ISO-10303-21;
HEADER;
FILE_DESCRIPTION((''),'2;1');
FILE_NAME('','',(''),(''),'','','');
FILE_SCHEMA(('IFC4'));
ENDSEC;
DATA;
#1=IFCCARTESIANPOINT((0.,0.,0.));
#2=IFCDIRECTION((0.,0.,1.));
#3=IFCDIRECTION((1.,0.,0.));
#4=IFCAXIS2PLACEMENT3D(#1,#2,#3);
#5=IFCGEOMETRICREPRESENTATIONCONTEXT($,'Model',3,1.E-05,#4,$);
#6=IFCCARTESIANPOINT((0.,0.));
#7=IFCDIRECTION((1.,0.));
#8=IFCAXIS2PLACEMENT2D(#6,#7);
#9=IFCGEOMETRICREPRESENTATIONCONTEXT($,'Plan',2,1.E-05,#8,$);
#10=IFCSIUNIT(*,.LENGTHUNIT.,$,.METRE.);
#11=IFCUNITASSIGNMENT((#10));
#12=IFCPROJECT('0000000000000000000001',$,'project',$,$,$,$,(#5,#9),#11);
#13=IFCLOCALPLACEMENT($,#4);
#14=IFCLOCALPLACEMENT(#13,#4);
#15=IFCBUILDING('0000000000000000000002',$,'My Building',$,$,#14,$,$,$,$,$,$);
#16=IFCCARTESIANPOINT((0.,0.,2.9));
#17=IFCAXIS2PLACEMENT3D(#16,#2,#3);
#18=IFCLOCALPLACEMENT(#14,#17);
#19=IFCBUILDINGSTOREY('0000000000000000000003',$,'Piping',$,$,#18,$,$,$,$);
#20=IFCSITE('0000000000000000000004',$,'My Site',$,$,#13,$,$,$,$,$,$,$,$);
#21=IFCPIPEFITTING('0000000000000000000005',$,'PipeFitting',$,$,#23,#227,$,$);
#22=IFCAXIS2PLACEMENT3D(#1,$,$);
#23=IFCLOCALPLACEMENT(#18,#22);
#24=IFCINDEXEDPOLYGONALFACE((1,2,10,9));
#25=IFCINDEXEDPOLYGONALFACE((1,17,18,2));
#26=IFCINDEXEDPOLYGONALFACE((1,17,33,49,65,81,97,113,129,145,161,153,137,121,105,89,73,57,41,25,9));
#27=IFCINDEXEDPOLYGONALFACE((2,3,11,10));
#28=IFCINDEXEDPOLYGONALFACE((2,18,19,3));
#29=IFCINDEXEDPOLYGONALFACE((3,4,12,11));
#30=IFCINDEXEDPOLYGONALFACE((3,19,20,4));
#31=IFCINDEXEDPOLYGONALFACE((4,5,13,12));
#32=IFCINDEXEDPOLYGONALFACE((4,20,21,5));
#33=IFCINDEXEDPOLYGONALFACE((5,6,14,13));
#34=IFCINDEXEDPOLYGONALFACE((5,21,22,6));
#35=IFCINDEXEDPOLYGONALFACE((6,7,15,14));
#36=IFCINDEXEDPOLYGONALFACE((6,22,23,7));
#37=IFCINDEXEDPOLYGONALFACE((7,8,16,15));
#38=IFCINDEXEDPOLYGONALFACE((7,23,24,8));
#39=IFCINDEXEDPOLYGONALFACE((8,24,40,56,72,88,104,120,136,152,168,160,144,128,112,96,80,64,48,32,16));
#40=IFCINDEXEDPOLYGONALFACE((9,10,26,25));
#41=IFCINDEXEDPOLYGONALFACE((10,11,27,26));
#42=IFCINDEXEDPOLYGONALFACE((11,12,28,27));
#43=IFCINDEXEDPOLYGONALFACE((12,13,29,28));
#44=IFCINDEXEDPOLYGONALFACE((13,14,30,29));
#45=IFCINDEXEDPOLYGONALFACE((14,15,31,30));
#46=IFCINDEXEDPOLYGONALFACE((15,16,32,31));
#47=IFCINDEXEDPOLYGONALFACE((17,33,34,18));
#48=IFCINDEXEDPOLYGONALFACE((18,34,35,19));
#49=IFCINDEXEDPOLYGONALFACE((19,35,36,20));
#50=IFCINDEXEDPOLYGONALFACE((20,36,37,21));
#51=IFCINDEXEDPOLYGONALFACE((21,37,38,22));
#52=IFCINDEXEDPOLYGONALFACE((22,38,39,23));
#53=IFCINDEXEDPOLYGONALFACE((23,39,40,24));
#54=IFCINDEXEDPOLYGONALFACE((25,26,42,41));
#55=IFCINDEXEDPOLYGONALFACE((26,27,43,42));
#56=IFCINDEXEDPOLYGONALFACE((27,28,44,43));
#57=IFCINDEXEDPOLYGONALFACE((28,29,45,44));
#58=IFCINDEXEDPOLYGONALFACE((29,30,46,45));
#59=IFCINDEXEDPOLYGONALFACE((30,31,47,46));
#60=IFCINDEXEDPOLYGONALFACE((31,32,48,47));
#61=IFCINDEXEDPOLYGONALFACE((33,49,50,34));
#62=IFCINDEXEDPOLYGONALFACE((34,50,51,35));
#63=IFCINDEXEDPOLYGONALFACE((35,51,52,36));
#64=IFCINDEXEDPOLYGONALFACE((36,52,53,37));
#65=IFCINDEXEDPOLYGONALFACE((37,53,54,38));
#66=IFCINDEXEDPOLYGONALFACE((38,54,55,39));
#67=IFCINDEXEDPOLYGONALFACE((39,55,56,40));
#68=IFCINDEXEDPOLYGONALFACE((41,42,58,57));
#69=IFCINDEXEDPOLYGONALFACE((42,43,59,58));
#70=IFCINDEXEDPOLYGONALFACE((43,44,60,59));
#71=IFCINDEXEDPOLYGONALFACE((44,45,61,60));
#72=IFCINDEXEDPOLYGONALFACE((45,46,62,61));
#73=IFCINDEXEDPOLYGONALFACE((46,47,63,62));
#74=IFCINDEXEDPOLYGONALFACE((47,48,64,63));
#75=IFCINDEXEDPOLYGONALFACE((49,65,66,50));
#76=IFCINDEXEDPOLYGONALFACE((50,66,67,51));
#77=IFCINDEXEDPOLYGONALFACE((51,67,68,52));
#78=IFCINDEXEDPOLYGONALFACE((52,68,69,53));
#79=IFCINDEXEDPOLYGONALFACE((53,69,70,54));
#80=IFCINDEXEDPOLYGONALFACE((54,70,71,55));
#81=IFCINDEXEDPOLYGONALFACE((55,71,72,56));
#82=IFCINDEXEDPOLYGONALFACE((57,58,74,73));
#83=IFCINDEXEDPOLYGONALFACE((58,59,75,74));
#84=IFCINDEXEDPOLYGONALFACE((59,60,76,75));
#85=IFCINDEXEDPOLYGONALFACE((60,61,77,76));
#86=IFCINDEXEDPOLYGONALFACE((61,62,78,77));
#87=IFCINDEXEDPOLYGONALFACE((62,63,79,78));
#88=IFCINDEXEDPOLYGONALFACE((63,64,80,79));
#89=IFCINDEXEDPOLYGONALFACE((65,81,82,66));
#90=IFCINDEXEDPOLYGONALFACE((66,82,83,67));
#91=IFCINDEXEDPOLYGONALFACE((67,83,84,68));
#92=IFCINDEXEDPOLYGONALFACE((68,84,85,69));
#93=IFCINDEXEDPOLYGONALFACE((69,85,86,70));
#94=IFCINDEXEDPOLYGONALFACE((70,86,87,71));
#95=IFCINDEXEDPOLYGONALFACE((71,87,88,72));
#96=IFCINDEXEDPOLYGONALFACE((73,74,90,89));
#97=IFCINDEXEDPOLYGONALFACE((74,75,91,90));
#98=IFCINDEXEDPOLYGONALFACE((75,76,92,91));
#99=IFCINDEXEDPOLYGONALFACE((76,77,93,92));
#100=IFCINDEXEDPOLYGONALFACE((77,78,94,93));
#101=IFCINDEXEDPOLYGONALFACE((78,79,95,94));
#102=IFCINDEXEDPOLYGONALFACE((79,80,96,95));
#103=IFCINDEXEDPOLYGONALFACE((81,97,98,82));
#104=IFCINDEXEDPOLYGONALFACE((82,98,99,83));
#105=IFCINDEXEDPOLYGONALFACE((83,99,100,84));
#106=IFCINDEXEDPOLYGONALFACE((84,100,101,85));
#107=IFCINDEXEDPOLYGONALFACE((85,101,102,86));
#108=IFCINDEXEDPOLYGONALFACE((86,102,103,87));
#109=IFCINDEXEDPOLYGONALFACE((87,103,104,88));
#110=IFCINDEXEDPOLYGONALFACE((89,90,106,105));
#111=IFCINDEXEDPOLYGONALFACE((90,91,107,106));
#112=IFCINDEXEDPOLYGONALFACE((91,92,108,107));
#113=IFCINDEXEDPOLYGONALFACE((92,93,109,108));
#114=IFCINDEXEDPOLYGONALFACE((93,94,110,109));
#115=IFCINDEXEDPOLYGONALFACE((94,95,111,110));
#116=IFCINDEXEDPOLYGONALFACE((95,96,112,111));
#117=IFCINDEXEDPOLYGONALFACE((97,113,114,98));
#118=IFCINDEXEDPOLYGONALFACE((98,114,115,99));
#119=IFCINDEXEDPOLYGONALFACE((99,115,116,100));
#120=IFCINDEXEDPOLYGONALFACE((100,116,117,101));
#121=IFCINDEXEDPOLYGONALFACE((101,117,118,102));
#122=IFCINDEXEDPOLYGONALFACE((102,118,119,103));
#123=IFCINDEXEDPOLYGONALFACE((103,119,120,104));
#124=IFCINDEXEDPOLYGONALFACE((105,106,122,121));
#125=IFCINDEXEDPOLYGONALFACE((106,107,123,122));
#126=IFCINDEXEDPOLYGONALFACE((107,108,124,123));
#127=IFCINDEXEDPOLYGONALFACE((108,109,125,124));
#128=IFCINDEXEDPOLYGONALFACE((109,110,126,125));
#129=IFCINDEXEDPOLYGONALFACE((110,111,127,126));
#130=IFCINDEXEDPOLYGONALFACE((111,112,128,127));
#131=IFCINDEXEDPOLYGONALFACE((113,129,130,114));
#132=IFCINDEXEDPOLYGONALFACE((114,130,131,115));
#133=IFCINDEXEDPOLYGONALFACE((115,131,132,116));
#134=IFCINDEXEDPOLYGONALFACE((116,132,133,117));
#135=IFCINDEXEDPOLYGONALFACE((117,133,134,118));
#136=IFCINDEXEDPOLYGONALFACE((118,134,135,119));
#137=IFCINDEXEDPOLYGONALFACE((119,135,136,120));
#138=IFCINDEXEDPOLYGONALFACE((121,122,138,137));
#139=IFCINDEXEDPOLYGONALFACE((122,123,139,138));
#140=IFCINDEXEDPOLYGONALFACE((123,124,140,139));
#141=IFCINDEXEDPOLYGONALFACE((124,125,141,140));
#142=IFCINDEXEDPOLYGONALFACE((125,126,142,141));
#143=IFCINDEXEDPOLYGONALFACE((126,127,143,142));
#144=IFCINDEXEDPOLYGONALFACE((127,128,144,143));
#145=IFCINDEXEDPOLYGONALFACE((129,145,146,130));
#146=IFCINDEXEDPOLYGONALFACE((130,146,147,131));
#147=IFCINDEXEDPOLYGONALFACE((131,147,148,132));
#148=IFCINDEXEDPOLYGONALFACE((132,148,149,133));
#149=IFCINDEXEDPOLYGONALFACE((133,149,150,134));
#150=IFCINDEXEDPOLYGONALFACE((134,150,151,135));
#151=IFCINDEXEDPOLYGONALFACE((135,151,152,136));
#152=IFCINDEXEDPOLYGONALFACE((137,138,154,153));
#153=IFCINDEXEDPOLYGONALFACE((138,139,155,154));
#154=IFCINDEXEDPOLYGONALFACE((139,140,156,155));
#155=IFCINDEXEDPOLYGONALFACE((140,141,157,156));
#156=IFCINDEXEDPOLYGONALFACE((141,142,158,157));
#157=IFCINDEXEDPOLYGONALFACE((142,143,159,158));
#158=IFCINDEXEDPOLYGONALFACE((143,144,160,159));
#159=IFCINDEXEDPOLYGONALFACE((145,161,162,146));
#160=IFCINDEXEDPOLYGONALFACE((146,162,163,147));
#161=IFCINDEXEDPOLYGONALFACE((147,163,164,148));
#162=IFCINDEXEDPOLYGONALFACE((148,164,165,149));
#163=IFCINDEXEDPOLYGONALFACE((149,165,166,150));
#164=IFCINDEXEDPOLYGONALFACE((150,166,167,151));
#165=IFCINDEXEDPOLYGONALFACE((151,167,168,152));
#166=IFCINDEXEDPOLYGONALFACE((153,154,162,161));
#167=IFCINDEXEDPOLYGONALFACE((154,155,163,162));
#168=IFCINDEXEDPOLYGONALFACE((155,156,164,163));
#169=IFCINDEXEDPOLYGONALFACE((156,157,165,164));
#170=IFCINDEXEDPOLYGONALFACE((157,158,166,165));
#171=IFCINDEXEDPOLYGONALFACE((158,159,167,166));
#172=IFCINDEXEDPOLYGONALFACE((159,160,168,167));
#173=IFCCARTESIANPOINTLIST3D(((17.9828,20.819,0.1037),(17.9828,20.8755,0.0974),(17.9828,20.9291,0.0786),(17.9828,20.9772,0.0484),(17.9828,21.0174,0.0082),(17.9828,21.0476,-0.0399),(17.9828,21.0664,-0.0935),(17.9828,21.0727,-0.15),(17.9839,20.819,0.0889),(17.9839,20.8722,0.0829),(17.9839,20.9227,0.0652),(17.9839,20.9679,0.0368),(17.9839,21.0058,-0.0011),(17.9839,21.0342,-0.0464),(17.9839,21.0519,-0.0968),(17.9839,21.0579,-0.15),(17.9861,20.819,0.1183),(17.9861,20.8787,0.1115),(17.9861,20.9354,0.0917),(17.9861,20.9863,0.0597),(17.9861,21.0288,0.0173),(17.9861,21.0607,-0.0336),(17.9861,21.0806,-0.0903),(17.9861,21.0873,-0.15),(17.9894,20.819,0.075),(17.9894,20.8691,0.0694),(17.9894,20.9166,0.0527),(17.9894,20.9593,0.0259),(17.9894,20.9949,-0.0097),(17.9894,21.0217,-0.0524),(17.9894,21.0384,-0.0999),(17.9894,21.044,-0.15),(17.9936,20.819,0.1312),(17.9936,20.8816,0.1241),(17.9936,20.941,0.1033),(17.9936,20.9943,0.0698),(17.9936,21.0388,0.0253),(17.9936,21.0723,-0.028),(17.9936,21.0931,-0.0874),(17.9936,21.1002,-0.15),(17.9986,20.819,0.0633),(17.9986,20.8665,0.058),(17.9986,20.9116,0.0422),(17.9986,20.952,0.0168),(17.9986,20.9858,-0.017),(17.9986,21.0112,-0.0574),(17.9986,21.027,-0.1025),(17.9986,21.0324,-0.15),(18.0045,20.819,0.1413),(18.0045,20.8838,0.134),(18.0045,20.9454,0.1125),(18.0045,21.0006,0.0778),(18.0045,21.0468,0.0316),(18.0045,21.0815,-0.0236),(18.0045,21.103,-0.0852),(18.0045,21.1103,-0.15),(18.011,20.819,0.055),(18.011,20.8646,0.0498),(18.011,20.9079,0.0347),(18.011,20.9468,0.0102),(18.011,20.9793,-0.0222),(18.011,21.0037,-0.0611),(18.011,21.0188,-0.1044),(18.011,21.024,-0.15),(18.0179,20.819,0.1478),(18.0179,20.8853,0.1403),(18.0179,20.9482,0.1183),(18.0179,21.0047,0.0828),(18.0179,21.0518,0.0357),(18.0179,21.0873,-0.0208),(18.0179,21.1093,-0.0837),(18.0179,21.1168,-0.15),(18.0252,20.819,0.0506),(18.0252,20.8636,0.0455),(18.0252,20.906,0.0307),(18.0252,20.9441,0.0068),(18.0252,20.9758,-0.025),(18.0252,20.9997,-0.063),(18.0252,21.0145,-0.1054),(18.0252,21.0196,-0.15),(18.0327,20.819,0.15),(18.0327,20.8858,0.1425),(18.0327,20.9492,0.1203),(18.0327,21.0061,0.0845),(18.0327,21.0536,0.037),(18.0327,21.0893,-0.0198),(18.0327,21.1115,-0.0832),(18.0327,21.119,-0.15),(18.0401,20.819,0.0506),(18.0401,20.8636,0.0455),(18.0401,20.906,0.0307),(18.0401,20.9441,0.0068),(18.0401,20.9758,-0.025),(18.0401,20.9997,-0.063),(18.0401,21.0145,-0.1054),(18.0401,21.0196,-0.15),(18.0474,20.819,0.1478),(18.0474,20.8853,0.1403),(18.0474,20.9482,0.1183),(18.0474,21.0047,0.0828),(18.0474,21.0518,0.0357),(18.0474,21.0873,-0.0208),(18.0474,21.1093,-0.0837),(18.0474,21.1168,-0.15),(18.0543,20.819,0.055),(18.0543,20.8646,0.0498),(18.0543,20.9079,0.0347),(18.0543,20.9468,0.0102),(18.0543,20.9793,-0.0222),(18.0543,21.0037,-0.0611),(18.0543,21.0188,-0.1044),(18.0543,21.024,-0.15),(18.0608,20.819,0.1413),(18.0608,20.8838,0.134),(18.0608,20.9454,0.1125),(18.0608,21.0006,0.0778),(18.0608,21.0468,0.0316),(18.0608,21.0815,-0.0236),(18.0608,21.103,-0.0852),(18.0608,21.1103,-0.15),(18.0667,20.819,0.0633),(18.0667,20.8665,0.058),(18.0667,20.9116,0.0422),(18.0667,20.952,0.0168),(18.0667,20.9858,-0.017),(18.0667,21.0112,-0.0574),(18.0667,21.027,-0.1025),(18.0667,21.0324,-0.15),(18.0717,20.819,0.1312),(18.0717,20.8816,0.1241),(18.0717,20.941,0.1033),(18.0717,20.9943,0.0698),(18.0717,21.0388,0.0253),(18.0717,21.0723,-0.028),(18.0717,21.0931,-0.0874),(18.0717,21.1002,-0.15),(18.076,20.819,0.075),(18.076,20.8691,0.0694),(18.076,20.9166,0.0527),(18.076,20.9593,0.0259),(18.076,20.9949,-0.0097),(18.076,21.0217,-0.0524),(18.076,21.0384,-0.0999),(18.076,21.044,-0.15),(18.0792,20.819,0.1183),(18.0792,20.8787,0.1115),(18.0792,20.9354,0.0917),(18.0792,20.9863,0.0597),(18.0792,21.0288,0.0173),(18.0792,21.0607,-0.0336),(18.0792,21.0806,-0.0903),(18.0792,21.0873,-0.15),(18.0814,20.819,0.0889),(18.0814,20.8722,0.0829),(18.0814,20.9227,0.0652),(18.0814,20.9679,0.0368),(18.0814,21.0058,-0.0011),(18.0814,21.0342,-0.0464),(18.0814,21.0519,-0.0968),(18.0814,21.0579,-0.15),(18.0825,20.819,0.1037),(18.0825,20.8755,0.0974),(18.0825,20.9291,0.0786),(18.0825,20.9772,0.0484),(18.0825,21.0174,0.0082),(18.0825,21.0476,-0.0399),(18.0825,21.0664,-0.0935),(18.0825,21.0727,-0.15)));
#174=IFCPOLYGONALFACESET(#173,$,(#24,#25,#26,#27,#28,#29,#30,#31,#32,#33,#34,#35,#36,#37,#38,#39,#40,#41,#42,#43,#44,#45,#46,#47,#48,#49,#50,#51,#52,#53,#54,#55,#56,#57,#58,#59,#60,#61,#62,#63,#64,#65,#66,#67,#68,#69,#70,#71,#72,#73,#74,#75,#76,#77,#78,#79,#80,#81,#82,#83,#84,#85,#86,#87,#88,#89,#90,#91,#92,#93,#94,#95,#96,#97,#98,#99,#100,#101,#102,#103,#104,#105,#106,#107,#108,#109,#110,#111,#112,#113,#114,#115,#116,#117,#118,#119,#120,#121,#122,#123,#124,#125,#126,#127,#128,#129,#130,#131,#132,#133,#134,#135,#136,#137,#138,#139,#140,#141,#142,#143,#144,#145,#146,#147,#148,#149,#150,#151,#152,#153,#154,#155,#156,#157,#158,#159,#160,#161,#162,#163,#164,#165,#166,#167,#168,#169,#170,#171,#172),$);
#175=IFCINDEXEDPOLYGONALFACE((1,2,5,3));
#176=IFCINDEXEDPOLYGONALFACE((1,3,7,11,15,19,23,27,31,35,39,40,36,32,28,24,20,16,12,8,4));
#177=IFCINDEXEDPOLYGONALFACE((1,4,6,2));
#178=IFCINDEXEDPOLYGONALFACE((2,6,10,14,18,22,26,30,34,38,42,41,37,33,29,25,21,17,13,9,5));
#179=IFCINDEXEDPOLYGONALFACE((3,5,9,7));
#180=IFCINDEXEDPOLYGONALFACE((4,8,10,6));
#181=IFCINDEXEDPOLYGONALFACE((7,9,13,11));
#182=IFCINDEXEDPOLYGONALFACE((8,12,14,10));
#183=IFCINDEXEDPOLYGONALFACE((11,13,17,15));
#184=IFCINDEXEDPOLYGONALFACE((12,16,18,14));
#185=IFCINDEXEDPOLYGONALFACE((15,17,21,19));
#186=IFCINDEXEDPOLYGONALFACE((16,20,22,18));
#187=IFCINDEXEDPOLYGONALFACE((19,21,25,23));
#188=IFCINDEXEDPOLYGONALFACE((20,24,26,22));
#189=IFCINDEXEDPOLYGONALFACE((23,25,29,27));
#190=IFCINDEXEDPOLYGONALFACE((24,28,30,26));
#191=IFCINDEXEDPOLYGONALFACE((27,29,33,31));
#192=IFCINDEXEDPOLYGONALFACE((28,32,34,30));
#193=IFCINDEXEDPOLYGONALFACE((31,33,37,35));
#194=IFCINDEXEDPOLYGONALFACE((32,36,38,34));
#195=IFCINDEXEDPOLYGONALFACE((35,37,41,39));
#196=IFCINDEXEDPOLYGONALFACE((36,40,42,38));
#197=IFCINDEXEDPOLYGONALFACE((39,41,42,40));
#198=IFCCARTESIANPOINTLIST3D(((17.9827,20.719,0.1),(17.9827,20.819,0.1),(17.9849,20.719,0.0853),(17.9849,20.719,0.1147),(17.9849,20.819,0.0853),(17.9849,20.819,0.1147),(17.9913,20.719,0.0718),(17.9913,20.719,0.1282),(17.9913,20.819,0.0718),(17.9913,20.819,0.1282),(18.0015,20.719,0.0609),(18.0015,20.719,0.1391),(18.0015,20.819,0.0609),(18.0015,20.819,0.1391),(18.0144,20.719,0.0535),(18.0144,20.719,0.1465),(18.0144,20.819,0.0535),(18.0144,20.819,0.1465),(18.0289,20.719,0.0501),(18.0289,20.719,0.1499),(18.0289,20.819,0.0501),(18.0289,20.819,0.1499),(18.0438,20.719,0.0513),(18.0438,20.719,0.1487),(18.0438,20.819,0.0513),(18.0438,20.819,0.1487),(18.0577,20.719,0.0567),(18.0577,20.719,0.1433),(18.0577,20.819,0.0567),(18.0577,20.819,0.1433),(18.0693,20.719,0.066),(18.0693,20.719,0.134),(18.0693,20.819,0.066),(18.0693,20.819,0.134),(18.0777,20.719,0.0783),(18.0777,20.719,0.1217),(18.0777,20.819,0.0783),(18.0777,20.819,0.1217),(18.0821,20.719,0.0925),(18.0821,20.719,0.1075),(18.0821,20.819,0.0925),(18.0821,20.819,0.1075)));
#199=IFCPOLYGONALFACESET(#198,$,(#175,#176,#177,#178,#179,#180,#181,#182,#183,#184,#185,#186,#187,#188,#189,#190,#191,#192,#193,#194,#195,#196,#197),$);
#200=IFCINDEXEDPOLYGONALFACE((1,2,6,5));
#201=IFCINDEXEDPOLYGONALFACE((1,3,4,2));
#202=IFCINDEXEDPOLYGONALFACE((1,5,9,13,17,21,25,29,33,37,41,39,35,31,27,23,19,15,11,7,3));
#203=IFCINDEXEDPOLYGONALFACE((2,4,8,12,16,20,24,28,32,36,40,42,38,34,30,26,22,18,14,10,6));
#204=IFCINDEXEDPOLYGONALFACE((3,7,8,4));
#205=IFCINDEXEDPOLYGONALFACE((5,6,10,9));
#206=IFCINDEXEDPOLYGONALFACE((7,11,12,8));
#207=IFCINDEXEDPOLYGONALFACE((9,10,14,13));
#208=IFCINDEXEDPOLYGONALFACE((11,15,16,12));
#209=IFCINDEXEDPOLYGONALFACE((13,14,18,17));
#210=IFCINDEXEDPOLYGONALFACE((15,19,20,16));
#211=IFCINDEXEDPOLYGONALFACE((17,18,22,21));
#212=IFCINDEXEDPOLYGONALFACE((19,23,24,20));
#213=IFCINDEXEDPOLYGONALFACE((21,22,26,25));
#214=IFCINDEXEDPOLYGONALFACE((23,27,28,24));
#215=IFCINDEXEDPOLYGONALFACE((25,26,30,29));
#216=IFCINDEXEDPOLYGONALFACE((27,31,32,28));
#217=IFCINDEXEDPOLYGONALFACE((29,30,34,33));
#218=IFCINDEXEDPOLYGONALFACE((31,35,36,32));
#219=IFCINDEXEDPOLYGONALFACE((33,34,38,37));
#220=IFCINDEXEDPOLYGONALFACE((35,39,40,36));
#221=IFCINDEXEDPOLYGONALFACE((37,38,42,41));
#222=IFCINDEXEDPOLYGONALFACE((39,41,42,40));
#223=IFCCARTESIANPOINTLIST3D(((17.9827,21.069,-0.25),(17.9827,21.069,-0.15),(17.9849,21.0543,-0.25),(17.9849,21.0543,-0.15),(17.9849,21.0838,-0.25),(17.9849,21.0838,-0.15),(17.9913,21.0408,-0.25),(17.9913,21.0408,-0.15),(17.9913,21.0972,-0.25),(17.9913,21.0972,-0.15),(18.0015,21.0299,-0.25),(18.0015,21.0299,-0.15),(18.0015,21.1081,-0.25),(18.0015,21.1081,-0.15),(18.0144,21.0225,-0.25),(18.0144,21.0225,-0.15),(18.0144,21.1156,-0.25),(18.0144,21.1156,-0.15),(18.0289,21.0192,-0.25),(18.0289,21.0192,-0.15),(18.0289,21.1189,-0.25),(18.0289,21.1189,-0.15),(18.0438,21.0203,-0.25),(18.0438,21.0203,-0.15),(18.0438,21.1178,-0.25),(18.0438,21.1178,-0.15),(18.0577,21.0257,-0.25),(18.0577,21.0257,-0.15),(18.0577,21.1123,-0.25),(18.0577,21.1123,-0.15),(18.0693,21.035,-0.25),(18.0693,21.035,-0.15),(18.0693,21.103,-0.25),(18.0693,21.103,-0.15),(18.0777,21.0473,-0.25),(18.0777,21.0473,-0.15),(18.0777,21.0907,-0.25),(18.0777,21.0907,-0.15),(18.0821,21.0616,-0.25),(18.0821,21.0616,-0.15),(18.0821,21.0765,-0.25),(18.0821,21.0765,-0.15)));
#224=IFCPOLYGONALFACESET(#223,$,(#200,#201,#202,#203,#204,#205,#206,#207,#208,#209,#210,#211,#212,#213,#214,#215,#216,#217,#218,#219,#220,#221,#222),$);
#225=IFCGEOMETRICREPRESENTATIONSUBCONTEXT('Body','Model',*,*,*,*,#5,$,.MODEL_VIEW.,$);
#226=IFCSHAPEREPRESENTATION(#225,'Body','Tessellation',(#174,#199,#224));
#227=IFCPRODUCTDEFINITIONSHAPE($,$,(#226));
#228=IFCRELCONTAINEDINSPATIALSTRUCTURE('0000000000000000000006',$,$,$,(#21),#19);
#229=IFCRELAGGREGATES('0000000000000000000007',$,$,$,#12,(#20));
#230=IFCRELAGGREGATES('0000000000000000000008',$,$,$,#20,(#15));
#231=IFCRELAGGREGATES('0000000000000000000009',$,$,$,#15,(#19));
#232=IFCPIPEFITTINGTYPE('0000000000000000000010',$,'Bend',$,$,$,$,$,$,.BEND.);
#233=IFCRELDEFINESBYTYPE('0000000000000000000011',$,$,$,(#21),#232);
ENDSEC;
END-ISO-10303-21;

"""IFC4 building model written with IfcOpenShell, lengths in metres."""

from ifc_helpers import new_model, entity, si_unit, frame, origin_with_axes, origin_2d_with_axis, place, context, subcontext, project, spatial, circle, extrude, source, transform, mapped, type_object, type_shapes, element, save


model = new_model("IFC4")

# Units and contexts
model_context = context("Model", 3, precision=1e-05, world=origin_with_axes())
plan_context = context("Plan", 2, precision=1e-05, world=origin_2d_with_axis())
body_context = subcontext(model_context, "Body", "Model", "MODEL_VIEW")
ifc_project = project(units=[si_unit("LENGTHUNIT", "METRE")], contexts=[model_context, plan_context])

# Site, building, storey
site_placement = place(None, origin_with_axes())
site = spatial("IfcSite", under=ifc_project, at=site_placement, Name="My Site")
building_placement = place(site_placement, origin_with_axes())
building = spatial("IfcBuilding", under=site, at=building_placement, Name="My Building")
storey_placement = place(building_placement, frame((0.0, 0.0, 2.9), z_axis=(0.0, 0.0, 1.0), x_axis=(1.0, 0.0, 0.0)))
storey = spatial("IfcBuildingStorey", under=building, at=storey_placement, Name="Piping")

# Pipe fitting
pipe_fitting_type = type_object("IfcPipeFittingType", Name="Bend", PredefinedType="BEND")
shared_shape = source(origin_with_axes(), body_context, "Body", "SolidModel", [
    entity("IfcSweptDiskSolid", entity("IfcIndexedPolyCurve", entity("IfcCartesianPointList3D", [[0.0, 0.0, 0.1], [0.0, -0.0732, 0.2768], [0.0, -0.25, 0.35]]), [entity("IfcArcIndex", [1, 2, 3])]), 0.05),
    extrude(circle(Radius=0.05), origin_with_axes(), (0.0, 0.0, 1.0), 0.1),
    extrude(circle(Radius=0.05), frame((0.0, -0.25, 0.35), z_axis=(0.0, -1.0, -0.000001), x_axis=(1.0, 0.0, 0.0)), (0.0, 0.0, 1.0), 0.1),
])
type_shapes(pipe_fitting_type, [shared_shape])
for number, where, z_axis, x_axis, name in (
    (1, (18.0327, 20.719, 0.1), (0.0, 1.0, 0.0), (-1.0, 0.0, 0.0), "PipeFitting"),
):
    element("IfcPipeFitting", number, at=place(storey_placement, frame(where, z_axis=z_axis, x_axis=x_axis)), inside=storey, type_object=pipe_fitting_type, Name=name, context=body_context, shape_type="MappedRepresentation", body=[
        mapped(shared_shape, transform((0.0, 0.0, 0.0), x_axis=(1.0, 0.0, 0.0), y_axis=(0.0, 1.0, 0.0), z_axis=(0.0, 0.0, 1.0), scale=1.0)),
    ])

save(model, "model.ifc")
